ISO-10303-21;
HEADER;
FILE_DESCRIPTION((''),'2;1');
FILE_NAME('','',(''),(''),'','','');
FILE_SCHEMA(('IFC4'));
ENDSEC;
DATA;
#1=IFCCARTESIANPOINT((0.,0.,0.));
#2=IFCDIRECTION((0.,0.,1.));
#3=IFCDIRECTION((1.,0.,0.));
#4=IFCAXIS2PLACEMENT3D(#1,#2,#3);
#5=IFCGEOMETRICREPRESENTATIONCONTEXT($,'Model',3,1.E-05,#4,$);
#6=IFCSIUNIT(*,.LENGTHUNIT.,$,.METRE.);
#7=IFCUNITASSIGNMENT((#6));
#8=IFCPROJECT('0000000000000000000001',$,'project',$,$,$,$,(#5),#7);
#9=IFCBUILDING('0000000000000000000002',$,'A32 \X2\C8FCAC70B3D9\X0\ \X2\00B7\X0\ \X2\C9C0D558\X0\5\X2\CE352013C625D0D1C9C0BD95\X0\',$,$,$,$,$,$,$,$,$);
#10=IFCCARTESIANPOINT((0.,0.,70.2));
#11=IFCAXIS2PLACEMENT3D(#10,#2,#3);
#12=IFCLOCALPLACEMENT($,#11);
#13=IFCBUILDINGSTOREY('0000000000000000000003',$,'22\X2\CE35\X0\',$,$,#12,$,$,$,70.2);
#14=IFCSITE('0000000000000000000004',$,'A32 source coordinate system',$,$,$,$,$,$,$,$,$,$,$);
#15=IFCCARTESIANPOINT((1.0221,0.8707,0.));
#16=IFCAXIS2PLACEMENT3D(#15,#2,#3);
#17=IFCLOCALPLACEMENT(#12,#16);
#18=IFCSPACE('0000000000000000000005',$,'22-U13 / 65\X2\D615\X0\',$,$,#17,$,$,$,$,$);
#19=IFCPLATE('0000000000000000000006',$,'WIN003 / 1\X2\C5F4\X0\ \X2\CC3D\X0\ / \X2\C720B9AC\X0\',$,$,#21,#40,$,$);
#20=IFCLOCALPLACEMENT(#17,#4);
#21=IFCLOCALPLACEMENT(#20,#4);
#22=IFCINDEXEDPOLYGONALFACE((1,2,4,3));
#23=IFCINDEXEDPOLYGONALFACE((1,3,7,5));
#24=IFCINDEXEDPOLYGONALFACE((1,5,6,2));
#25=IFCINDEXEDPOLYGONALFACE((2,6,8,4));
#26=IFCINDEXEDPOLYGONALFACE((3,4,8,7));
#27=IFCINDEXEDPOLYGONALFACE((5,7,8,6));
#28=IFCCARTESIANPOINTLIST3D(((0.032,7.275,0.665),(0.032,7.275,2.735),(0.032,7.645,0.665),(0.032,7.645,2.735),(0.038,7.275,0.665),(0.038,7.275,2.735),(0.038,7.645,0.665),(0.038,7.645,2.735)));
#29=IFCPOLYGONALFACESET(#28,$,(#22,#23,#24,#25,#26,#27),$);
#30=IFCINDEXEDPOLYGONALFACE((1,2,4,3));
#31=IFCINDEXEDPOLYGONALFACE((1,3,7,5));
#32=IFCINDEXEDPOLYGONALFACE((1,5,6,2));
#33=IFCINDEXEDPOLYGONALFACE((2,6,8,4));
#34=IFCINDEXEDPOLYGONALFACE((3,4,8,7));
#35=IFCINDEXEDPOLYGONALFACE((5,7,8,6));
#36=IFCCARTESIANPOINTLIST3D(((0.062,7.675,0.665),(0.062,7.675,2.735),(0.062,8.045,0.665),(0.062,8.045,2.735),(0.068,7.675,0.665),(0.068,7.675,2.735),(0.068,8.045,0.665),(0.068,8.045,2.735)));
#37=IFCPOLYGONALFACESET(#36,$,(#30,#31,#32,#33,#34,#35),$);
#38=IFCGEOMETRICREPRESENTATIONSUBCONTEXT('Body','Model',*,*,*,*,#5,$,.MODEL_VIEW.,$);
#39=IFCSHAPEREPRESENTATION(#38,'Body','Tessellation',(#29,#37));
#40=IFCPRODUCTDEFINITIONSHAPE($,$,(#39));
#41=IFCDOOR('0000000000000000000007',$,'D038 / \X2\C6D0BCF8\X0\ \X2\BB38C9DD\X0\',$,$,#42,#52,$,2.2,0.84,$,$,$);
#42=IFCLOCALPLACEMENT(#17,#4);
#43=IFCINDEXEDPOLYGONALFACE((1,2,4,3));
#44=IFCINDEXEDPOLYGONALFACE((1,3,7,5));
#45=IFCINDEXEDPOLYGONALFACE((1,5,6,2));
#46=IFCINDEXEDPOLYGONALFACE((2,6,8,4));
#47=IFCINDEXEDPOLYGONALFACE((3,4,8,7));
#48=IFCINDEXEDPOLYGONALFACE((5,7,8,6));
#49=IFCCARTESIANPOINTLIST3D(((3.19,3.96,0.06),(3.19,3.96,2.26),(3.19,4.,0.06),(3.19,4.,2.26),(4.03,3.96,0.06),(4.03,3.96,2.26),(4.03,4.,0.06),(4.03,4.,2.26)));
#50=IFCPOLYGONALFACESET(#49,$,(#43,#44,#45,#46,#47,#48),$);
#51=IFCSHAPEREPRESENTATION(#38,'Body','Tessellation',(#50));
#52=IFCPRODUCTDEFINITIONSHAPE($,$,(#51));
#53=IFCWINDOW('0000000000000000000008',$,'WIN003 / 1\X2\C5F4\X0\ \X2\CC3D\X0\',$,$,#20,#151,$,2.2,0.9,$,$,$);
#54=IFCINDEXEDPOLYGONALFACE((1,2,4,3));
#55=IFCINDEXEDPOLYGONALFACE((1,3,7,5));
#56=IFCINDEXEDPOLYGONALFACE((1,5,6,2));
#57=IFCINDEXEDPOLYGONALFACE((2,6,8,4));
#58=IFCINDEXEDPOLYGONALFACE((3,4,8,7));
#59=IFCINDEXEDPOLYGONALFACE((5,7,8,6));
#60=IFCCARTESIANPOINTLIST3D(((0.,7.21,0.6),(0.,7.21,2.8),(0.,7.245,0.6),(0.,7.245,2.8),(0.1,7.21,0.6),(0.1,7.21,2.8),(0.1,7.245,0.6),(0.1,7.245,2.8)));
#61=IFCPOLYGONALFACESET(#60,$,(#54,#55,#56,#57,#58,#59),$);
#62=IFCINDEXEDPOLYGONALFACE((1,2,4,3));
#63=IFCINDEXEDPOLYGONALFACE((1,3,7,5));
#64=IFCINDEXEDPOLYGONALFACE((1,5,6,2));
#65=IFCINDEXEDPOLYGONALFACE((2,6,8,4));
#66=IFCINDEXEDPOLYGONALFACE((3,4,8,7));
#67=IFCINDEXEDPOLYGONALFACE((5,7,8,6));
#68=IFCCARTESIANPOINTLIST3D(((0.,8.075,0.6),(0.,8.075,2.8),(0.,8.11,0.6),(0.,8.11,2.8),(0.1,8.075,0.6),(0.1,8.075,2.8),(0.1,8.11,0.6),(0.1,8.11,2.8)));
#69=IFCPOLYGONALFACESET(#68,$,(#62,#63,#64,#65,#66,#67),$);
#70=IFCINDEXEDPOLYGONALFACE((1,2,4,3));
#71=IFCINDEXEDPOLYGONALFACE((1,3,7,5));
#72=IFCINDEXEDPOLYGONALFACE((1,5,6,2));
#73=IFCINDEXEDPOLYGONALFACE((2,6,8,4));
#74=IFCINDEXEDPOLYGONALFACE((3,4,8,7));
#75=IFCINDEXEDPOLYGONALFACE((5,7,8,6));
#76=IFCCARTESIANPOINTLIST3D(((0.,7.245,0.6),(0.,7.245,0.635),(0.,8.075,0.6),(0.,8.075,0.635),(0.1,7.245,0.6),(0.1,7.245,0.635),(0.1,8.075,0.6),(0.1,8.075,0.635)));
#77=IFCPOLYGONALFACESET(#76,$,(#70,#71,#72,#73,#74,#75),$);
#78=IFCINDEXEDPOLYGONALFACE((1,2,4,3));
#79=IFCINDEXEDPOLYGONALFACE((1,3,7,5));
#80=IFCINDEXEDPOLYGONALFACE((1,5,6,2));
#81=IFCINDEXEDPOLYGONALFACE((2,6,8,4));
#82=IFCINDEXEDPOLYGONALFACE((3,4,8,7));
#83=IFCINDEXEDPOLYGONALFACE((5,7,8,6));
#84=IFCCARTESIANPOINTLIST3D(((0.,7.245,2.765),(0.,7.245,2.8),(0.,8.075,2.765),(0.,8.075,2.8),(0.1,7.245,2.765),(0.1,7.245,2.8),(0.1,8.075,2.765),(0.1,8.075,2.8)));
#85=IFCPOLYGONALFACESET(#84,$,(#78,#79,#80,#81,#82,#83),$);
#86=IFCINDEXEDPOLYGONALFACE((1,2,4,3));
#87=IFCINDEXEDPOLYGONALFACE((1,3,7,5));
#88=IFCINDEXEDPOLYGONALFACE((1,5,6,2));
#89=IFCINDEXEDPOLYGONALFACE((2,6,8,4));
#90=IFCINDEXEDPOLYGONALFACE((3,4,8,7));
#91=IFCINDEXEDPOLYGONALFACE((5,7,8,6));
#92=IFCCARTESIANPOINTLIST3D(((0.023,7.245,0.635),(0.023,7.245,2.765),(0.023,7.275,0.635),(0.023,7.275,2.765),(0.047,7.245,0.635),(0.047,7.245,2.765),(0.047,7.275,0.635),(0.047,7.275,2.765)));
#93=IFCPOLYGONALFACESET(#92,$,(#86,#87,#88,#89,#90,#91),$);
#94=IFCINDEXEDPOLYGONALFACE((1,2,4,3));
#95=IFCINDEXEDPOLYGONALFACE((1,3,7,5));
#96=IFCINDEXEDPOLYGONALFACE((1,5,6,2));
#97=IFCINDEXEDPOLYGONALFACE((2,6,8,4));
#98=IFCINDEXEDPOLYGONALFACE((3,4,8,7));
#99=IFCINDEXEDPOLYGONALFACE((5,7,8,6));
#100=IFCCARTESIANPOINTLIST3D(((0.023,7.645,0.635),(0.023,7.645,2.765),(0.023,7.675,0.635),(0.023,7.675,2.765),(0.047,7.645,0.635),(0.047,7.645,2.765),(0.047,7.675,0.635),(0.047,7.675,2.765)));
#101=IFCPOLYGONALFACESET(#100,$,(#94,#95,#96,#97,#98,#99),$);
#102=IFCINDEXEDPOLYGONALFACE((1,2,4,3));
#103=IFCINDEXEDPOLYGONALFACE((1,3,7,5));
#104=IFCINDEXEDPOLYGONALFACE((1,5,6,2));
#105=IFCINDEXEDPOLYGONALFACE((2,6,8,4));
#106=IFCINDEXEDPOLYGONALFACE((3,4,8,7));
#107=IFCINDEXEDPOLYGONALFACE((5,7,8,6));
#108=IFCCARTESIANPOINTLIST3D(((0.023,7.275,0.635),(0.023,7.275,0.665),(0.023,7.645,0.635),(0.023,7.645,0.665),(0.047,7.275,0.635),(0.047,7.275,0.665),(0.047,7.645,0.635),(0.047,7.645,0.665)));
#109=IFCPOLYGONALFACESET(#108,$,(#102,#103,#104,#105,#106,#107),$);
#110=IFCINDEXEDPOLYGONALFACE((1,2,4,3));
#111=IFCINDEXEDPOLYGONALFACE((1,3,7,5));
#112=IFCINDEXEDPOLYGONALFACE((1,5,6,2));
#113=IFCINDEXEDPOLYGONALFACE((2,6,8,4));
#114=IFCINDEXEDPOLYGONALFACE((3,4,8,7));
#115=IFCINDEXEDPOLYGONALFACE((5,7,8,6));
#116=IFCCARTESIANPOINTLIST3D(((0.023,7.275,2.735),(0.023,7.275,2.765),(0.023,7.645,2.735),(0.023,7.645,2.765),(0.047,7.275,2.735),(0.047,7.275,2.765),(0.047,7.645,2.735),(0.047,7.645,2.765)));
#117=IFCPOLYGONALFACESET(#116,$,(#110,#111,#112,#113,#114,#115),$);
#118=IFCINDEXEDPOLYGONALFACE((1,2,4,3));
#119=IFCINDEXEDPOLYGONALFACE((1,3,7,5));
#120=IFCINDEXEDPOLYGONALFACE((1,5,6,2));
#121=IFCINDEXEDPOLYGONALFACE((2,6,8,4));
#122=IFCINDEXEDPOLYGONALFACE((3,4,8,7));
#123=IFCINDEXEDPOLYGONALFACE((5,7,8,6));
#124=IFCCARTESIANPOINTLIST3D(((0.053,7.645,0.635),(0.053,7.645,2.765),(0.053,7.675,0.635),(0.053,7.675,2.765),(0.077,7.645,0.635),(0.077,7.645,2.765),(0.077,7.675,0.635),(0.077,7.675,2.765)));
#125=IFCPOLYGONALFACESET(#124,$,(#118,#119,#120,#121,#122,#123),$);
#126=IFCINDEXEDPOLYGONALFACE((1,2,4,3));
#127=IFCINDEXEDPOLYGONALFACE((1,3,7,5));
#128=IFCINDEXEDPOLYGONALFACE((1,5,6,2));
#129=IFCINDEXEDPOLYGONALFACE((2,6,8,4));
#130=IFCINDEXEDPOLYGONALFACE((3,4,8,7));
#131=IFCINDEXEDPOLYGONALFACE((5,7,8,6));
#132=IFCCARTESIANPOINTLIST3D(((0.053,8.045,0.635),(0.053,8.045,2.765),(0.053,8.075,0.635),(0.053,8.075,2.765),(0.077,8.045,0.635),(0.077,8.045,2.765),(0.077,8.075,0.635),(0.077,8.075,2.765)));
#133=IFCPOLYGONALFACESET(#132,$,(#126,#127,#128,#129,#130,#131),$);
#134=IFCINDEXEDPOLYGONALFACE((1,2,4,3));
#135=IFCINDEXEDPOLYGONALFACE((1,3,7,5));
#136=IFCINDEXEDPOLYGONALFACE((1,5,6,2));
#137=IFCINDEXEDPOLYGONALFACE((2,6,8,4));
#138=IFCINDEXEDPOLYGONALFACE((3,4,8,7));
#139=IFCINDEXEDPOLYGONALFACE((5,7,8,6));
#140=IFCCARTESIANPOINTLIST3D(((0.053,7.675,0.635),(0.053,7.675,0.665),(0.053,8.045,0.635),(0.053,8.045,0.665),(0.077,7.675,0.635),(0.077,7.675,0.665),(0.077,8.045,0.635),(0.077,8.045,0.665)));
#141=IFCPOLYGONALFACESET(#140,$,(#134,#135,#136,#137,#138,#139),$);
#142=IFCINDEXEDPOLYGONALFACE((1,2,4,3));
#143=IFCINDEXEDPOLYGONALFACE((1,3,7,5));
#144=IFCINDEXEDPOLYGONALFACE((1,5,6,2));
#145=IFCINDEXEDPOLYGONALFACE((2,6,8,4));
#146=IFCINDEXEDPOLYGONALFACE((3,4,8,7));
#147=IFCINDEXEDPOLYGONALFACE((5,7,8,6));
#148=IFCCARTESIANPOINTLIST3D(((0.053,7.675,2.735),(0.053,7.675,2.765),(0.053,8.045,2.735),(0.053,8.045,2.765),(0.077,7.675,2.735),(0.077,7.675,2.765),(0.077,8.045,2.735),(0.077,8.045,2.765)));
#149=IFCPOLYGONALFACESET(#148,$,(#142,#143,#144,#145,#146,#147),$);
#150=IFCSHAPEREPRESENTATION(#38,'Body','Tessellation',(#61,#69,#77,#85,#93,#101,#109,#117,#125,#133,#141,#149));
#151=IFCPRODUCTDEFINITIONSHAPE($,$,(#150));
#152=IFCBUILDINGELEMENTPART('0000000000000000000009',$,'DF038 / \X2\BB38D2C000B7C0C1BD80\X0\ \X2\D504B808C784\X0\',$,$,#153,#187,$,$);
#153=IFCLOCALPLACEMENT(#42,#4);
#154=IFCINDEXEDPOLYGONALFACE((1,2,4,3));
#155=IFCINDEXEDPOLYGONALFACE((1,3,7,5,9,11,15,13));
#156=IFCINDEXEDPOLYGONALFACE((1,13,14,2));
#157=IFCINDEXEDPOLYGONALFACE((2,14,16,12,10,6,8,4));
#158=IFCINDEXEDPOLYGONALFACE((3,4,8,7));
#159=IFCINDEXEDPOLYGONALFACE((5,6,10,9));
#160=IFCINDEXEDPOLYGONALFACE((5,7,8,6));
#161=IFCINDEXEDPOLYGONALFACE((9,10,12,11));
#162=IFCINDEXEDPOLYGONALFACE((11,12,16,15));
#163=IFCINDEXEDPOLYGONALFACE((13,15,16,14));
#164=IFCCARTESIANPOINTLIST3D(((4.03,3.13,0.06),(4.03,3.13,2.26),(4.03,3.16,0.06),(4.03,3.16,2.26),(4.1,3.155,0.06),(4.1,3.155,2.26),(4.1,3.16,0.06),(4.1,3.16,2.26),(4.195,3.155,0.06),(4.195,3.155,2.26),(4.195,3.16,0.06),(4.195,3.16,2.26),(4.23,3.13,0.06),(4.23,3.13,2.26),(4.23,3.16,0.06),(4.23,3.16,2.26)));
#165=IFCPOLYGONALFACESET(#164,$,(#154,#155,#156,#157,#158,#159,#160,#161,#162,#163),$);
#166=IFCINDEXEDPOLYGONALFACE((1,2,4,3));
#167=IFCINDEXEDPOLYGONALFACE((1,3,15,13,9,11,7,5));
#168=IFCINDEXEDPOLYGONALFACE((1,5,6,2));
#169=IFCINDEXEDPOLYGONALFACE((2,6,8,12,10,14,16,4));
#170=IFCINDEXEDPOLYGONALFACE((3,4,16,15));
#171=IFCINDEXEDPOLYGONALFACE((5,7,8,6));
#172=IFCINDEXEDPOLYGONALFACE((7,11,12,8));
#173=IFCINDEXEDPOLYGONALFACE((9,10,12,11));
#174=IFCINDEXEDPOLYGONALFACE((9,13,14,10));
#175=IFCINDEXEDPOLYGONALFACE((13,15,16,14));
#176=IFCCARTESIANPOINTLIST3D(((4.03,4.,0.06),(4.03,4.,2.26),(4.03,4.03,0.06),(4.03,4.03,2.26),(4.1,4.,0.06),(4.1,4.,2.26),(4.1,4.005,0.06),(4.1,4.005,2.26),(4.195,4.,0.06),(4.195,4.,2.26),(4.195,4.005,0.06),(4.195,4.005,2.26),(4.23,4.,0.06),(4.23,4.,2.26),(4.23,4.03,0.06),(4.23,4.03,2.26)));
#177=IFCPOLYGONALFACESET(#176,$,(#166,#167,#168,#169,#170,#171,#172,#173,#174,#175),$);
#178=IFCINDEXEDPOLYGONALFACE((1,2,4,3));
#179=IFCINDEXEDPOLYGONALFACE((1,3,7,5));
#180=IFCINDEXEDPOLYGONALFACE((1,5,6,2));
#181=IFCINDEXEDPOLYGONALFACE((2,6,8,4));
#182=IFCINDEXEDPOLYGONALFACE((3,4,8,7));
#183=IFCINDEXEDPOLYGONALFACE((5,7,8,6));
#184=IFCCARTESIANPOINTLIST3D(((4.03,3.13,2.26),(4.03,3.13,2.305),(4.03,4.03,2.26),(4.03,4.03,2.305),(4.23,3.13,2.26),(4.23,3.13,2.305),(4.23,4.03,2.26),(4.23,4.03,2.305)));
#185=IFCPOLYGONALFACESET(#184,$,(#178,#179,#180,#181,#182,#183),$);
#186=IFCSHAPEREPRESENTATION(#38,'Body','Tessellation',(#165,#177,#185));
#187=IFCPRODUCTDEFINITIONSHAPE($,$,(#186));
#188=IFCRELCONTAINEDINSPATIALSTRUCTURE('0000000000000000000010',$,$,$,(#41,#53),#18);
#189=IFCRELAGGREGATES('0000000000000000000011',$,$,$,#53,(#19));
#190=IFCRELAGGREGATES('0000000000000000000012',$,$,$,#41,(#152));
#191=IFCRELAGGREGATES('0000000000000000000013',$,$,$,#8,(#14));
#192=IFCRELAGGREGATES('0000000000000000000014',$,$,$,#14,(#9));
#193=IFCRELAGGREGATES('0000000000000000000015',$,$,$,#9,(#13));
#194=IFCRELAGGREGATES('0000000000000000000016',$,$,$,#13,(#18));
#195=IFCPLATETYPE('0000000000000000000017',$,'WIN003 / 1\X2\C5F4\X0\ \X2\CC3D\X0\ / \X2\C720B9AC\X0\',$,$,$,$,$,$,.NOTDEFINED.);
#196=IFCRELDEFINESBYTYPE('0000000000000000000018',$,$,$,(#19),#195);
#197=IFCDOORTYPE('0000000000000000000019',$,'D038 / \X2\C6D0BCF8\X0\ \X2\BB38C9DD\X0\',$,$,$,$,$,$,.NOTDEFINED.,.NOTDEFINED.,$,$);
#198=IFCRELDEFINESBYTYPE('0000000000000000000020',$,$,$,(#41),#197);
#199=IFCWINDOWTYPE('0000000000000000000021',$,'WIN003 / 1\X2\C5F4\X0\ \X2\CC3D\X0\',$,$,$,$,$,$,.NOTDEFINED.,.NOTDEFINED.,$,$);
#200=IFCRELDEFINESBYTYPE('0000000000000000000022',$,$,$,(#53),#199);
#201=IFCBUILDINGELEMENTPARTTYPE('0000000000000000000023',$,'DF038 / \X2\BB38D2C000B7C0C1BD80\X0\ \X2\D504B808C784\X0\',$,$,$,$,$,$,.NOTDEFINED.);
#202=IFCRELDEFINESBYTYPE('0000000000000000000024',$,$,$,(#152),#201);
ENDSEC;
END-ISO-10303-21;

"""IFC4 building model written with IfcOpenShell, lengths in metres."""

from ifc_helpers import new_model, si_unit, frame, origin, origin_with_axes, place, context, subcontext, project, spatial, polyline, outline, extrude, source, transform, mapped, type_object, type_shapes, element, aggregate, save


model = new_model("IFC4")

# Units and contexts
model_context = context("Model", 3, precision=1e-05, world=origin_with_axes())
body_context = subcontext(model_context, "Body", "Model", "MODEL_VIEW")
ifc_project = project(units=[si_unit("LENGTHUNIT", "METRE")], contexts=[model_context])

# Plate
storey_placement = place(None, frame((0.0, 0.0, 70.2), z_axis=(0.0, 0.0, 1.0), x_axis=(1.0, 0.0, 0.0)))
space_placement = place(storey_placement, frame((1.0221, 0.8707, 0.0), z_axis=(0.0, 0.0, 1.0), x_axis=(1.0, 0.0, 0.0)))
plate_type_1 = type_object("IfcPlateType", Name="WIN003 / 1열 창 / 유리", PredefinedType="NOTDEFINED")
shared_shape_1 = source(origin(), body_context, "Body", "SweptSolid", [
    extrude(outline(polyline([(0.032, 7.275), (0.032, 7.645), (0.038, 7.645), (0.038, 7.275), (0.032, 7.275)])), frame((0.0, 0.0, 0.665)), (0.0, 0.0, 1.0), 2.07),
    extrude(outline(polyline([(0.062, 7.675), (0.062, 8.045), (0.068, 8.045), (0.068, 7.675), (0.062, 7.675)])), frame((0.0, 0.0, 0.665)), (0.0, 0.0, 1.0), 2.07),
])
type_shapes(plate_type_1, [shared_shape_1])
window_1_placement = place(space_placement, origin_with_axes())
plate_1_placement = place(window_1_placement, origin_with_axes())
plate_1 = element("IfcPlate", 1, at=plate_1_placement, type_object=plate_type_1, Name="WIN003 / 1열 창 / 유리", context=body_context, shape_type="MappedRepresentation", body=[
    mapped(shared_shape_1, transform((0.0, 0.0, 0.0), scale=1.0)),
])

# Site, building, storey, space
site = spatial("IfcSite", under=ifc_project, Name="A32 source coordinate system")
building = spatial("IfcBuilding", under=site, Name="A32 주거동 · 지하5층–옥탑지붕")
storey = spatial("IfcBuildingStorey", under=building, at=storey_placement, Name="22층", Elevation=70.2)
space = spatial("IfcSpace", under=storey, at=space_placement, Name="22-U13 / 65형")

# Door
door_type_1 = type_object("IfcDoorType", Name="D038 / 원본 문짝", OperationType="NOTDEFINED", PredefinedType="NOTDEFINED")
shared_shape_2 = source(origin(), body_context, "Body", "SweptSolid", [
    extrude(outline(polyline([(3.19, 3.96), (3.19, 4.0), (4.03, 4.0), (4.03, 3.96), (3.19, 3.96)])), frame((0.0, 0.0, 0.06)), (0.0, 0.0, 1.0), 2.2),
])
type_shapes(door_type_1, [shared_shape_2])
door_1_placement = place(space_placement, origin_with_axes())
door_1 = element("IfcDoor", 2, at=door_1_placement, inside=space, type_object=door_type_1, Name="D038 / 원본 문짝", OverallHeight=2.2, OverallWidth=0.84, context=body_context, shape_type="MappedRepresentation", body=[
    mapped(shared_shape_2, transform((0.0, 0.0, 0.0), scale=1.0)),
])

# Window
window_type_1 = type_object("IfcWindowType", Name="WIN003 / 1열 창", PartitioningType="NOTDEFINED", PredefinedType="NOTDEFINED")
shared_shape_3 = source(origin(), body_context, "Body", "SweptSolid", [
    extrude(outline(polyline([(0.0, 7.21), (0.0, 7.245), (0.1, 7.245), (0.1, 7.21), (0.0, 7.21)])), frame((0.0, 0.0, 0.6)), (0.0, 0.0, 1.0), 2.2),
    extrude(outline(polyline([(0.0, 8.075), (0.0, 8.11), (0.1, 8.11), (0.1, 8.075), (0.0, 8.075)])), frame((0.0, 0.0, 0.6)), (0.0, 0.0, 1.0), 2.2),
    extrude(outline(polyline([(0.0, 7.245), (0.0, 8.075), (0.1, 8.075), (0.1, 7.245), (0.0, 7.245)])), frame((0.0, 0.0, 0.6)), (0.0, 0.0, 1.0), 0.035),
    extrude(outline(polyline([(0.0, 7.245), (0.0, 8.075), (0.1, 8.075), (0.1, 7.245), (0.0, 7.245)])), frame((0.0, 0.0, 2.765)), (0.0, 0.0, 1.0), 0.035),
    extrude(outline(polyline([(0.023, 7.245), (0.023, 7.275), (0.047, 7.275), (0.047, 7.245), (0.023, 7.245)])), frame((0.0, 0.0, 0.635)), (0.0, 0.0, 1.0), 2.13),
    extrude(outline(polyline([(0.023, 7.645), (0.023, 7.675), (0.047, 7.675), (0.047, 7.645), (0.023, 7.645)])), frame((0.0, 0.0, 0.635)), (0.0, 0.0, 1.0), 2.13),
    extrude(outline(polyline([(0.023, 7.275), (0.023, 7.645), (0.047, 7.645), (0.047, 7.275), (0.023, 7.275)])), frame((0.0, 0.0, 0.635)), (0.0, 0.0, 1.0), 0.03),
    extrude(outline(polyline([(0.023, 7.275), (0.023, 7.645), (0.047, 7.645), (0.047, 7.275), (0.023, 7.275)])), frame((0.0, 0.0, 2.735)), (0.0, 0.0, 1.0), 0.03),
    extrude(outline(polyline([(0.053, 7.645), (0.053, 7.675), (0.077, 7.675), (0.077, 7.645), (0.053, 7.645)])), frame((0.0, 0.0, 0.635)), (0.0, 0.0, 1.0), 2.13),
    extrude(outline(polyline([(0.053, 8.045), (0.053, 8.075), (0.077, 8.075), (0.077, 8.045), (0.053, 8.045)])), frame((0.0, 0.0, 0.635)), (0.0, 0.0, 1.0), 2.13),
    extrude(outline(polyline([(0.053, 7.675), (0.053, 8.045), (0.077, 8.045), (0.077, 7.675), (0.053, 7.675)])), frame((0.0, 0.0, 0.635)), (0.0, 0.0, 1.0), 0.03),
    extrude(outline(polyline([(0.053, 7.675), (0.053, 8.045), (0.077, 8.045), (0.077, 7.675), (0.053, 7.675)])), frame((0.0, 0.0, 2.735)), (0.0, 0.0, 1.0), 0.03),
])
type_shapes(window_type_1, [shared_shape_3])
window_1 = element("IfcWindow", 3, at=window_1_placement, inside=space, type_object=window_type_1, Name="WIN003 / 1열 창", OverallHeight=2.2, OverallWidth=0.9, context=body_context, shape_type="MappedRepresentation", body=[
    mapped(shared_shape_3, transform((0.0, 0.0, 0.0), scale=1.0)),
])
aggregate(window_1, [plate_1])

# Building element part
building_element_part_type_1 = type_object("IfcBuildingElementPartType", Name="DF038 / 문틀·상부 프레임", PredefinedType="NOTDEFINED")
shared_shape_4 = source(origin(), body_context, "Body", "SweptSolid", [
    extrude(outline(polyline([(4.03, 3.16), (4.1, 3.16), (4.1, 3.155), (4.195, 3.155), (4.195, 3.16), (4.23, 3.16), (4.23, 3.13), (4.03, 3.13), (4.03, 3.16)])), frame((0.0, 0.0, 0.06)), (0.0, 0.0, 1.0), 2.2),
    extrude(outline(polyline([(4.23, 4.03), (4.23, 4.0), (4.195, 4.0), (4.195, 4.005), (4.1, 4.005), (4.1, 4.0), (4.03, 4.0), (4.03, 4.03), (4.23, 4.03)])), frame((0.0, 0.0, 0.06)), (0.0, 0.0, 1.0), 2.2),
    extrude(outline(polyline([(4.03, 3.13), (4.03, 4.03), (4.23, 4.03), (4.23, 3.13), (4.03, 3.13)])), frame((0.0, 0.0, 2.26)), (0.0, 0.0, 1.0), 0.045),
])
type_shapes(building_element_part_type_1, [shared_shape_4])
building_element_part_1_placement = place(door_1_placement, origin_with_axes())
building_element_part_1 = element("IfcBuildingElementPart", 4, at=building_element_part_1_placement, type_object=building_element_part_type_1, Name="DF038 / 문틀·상부 프레임", context=body_context, shape_type="MappedRepresentation", body=[
    mapped(shared_shape_4, transform((0.0, 0.0, 0.0), scale=1.0)),
])
aggregate(door_1, [building_element_part_1])

save(model, "model.ifc")
